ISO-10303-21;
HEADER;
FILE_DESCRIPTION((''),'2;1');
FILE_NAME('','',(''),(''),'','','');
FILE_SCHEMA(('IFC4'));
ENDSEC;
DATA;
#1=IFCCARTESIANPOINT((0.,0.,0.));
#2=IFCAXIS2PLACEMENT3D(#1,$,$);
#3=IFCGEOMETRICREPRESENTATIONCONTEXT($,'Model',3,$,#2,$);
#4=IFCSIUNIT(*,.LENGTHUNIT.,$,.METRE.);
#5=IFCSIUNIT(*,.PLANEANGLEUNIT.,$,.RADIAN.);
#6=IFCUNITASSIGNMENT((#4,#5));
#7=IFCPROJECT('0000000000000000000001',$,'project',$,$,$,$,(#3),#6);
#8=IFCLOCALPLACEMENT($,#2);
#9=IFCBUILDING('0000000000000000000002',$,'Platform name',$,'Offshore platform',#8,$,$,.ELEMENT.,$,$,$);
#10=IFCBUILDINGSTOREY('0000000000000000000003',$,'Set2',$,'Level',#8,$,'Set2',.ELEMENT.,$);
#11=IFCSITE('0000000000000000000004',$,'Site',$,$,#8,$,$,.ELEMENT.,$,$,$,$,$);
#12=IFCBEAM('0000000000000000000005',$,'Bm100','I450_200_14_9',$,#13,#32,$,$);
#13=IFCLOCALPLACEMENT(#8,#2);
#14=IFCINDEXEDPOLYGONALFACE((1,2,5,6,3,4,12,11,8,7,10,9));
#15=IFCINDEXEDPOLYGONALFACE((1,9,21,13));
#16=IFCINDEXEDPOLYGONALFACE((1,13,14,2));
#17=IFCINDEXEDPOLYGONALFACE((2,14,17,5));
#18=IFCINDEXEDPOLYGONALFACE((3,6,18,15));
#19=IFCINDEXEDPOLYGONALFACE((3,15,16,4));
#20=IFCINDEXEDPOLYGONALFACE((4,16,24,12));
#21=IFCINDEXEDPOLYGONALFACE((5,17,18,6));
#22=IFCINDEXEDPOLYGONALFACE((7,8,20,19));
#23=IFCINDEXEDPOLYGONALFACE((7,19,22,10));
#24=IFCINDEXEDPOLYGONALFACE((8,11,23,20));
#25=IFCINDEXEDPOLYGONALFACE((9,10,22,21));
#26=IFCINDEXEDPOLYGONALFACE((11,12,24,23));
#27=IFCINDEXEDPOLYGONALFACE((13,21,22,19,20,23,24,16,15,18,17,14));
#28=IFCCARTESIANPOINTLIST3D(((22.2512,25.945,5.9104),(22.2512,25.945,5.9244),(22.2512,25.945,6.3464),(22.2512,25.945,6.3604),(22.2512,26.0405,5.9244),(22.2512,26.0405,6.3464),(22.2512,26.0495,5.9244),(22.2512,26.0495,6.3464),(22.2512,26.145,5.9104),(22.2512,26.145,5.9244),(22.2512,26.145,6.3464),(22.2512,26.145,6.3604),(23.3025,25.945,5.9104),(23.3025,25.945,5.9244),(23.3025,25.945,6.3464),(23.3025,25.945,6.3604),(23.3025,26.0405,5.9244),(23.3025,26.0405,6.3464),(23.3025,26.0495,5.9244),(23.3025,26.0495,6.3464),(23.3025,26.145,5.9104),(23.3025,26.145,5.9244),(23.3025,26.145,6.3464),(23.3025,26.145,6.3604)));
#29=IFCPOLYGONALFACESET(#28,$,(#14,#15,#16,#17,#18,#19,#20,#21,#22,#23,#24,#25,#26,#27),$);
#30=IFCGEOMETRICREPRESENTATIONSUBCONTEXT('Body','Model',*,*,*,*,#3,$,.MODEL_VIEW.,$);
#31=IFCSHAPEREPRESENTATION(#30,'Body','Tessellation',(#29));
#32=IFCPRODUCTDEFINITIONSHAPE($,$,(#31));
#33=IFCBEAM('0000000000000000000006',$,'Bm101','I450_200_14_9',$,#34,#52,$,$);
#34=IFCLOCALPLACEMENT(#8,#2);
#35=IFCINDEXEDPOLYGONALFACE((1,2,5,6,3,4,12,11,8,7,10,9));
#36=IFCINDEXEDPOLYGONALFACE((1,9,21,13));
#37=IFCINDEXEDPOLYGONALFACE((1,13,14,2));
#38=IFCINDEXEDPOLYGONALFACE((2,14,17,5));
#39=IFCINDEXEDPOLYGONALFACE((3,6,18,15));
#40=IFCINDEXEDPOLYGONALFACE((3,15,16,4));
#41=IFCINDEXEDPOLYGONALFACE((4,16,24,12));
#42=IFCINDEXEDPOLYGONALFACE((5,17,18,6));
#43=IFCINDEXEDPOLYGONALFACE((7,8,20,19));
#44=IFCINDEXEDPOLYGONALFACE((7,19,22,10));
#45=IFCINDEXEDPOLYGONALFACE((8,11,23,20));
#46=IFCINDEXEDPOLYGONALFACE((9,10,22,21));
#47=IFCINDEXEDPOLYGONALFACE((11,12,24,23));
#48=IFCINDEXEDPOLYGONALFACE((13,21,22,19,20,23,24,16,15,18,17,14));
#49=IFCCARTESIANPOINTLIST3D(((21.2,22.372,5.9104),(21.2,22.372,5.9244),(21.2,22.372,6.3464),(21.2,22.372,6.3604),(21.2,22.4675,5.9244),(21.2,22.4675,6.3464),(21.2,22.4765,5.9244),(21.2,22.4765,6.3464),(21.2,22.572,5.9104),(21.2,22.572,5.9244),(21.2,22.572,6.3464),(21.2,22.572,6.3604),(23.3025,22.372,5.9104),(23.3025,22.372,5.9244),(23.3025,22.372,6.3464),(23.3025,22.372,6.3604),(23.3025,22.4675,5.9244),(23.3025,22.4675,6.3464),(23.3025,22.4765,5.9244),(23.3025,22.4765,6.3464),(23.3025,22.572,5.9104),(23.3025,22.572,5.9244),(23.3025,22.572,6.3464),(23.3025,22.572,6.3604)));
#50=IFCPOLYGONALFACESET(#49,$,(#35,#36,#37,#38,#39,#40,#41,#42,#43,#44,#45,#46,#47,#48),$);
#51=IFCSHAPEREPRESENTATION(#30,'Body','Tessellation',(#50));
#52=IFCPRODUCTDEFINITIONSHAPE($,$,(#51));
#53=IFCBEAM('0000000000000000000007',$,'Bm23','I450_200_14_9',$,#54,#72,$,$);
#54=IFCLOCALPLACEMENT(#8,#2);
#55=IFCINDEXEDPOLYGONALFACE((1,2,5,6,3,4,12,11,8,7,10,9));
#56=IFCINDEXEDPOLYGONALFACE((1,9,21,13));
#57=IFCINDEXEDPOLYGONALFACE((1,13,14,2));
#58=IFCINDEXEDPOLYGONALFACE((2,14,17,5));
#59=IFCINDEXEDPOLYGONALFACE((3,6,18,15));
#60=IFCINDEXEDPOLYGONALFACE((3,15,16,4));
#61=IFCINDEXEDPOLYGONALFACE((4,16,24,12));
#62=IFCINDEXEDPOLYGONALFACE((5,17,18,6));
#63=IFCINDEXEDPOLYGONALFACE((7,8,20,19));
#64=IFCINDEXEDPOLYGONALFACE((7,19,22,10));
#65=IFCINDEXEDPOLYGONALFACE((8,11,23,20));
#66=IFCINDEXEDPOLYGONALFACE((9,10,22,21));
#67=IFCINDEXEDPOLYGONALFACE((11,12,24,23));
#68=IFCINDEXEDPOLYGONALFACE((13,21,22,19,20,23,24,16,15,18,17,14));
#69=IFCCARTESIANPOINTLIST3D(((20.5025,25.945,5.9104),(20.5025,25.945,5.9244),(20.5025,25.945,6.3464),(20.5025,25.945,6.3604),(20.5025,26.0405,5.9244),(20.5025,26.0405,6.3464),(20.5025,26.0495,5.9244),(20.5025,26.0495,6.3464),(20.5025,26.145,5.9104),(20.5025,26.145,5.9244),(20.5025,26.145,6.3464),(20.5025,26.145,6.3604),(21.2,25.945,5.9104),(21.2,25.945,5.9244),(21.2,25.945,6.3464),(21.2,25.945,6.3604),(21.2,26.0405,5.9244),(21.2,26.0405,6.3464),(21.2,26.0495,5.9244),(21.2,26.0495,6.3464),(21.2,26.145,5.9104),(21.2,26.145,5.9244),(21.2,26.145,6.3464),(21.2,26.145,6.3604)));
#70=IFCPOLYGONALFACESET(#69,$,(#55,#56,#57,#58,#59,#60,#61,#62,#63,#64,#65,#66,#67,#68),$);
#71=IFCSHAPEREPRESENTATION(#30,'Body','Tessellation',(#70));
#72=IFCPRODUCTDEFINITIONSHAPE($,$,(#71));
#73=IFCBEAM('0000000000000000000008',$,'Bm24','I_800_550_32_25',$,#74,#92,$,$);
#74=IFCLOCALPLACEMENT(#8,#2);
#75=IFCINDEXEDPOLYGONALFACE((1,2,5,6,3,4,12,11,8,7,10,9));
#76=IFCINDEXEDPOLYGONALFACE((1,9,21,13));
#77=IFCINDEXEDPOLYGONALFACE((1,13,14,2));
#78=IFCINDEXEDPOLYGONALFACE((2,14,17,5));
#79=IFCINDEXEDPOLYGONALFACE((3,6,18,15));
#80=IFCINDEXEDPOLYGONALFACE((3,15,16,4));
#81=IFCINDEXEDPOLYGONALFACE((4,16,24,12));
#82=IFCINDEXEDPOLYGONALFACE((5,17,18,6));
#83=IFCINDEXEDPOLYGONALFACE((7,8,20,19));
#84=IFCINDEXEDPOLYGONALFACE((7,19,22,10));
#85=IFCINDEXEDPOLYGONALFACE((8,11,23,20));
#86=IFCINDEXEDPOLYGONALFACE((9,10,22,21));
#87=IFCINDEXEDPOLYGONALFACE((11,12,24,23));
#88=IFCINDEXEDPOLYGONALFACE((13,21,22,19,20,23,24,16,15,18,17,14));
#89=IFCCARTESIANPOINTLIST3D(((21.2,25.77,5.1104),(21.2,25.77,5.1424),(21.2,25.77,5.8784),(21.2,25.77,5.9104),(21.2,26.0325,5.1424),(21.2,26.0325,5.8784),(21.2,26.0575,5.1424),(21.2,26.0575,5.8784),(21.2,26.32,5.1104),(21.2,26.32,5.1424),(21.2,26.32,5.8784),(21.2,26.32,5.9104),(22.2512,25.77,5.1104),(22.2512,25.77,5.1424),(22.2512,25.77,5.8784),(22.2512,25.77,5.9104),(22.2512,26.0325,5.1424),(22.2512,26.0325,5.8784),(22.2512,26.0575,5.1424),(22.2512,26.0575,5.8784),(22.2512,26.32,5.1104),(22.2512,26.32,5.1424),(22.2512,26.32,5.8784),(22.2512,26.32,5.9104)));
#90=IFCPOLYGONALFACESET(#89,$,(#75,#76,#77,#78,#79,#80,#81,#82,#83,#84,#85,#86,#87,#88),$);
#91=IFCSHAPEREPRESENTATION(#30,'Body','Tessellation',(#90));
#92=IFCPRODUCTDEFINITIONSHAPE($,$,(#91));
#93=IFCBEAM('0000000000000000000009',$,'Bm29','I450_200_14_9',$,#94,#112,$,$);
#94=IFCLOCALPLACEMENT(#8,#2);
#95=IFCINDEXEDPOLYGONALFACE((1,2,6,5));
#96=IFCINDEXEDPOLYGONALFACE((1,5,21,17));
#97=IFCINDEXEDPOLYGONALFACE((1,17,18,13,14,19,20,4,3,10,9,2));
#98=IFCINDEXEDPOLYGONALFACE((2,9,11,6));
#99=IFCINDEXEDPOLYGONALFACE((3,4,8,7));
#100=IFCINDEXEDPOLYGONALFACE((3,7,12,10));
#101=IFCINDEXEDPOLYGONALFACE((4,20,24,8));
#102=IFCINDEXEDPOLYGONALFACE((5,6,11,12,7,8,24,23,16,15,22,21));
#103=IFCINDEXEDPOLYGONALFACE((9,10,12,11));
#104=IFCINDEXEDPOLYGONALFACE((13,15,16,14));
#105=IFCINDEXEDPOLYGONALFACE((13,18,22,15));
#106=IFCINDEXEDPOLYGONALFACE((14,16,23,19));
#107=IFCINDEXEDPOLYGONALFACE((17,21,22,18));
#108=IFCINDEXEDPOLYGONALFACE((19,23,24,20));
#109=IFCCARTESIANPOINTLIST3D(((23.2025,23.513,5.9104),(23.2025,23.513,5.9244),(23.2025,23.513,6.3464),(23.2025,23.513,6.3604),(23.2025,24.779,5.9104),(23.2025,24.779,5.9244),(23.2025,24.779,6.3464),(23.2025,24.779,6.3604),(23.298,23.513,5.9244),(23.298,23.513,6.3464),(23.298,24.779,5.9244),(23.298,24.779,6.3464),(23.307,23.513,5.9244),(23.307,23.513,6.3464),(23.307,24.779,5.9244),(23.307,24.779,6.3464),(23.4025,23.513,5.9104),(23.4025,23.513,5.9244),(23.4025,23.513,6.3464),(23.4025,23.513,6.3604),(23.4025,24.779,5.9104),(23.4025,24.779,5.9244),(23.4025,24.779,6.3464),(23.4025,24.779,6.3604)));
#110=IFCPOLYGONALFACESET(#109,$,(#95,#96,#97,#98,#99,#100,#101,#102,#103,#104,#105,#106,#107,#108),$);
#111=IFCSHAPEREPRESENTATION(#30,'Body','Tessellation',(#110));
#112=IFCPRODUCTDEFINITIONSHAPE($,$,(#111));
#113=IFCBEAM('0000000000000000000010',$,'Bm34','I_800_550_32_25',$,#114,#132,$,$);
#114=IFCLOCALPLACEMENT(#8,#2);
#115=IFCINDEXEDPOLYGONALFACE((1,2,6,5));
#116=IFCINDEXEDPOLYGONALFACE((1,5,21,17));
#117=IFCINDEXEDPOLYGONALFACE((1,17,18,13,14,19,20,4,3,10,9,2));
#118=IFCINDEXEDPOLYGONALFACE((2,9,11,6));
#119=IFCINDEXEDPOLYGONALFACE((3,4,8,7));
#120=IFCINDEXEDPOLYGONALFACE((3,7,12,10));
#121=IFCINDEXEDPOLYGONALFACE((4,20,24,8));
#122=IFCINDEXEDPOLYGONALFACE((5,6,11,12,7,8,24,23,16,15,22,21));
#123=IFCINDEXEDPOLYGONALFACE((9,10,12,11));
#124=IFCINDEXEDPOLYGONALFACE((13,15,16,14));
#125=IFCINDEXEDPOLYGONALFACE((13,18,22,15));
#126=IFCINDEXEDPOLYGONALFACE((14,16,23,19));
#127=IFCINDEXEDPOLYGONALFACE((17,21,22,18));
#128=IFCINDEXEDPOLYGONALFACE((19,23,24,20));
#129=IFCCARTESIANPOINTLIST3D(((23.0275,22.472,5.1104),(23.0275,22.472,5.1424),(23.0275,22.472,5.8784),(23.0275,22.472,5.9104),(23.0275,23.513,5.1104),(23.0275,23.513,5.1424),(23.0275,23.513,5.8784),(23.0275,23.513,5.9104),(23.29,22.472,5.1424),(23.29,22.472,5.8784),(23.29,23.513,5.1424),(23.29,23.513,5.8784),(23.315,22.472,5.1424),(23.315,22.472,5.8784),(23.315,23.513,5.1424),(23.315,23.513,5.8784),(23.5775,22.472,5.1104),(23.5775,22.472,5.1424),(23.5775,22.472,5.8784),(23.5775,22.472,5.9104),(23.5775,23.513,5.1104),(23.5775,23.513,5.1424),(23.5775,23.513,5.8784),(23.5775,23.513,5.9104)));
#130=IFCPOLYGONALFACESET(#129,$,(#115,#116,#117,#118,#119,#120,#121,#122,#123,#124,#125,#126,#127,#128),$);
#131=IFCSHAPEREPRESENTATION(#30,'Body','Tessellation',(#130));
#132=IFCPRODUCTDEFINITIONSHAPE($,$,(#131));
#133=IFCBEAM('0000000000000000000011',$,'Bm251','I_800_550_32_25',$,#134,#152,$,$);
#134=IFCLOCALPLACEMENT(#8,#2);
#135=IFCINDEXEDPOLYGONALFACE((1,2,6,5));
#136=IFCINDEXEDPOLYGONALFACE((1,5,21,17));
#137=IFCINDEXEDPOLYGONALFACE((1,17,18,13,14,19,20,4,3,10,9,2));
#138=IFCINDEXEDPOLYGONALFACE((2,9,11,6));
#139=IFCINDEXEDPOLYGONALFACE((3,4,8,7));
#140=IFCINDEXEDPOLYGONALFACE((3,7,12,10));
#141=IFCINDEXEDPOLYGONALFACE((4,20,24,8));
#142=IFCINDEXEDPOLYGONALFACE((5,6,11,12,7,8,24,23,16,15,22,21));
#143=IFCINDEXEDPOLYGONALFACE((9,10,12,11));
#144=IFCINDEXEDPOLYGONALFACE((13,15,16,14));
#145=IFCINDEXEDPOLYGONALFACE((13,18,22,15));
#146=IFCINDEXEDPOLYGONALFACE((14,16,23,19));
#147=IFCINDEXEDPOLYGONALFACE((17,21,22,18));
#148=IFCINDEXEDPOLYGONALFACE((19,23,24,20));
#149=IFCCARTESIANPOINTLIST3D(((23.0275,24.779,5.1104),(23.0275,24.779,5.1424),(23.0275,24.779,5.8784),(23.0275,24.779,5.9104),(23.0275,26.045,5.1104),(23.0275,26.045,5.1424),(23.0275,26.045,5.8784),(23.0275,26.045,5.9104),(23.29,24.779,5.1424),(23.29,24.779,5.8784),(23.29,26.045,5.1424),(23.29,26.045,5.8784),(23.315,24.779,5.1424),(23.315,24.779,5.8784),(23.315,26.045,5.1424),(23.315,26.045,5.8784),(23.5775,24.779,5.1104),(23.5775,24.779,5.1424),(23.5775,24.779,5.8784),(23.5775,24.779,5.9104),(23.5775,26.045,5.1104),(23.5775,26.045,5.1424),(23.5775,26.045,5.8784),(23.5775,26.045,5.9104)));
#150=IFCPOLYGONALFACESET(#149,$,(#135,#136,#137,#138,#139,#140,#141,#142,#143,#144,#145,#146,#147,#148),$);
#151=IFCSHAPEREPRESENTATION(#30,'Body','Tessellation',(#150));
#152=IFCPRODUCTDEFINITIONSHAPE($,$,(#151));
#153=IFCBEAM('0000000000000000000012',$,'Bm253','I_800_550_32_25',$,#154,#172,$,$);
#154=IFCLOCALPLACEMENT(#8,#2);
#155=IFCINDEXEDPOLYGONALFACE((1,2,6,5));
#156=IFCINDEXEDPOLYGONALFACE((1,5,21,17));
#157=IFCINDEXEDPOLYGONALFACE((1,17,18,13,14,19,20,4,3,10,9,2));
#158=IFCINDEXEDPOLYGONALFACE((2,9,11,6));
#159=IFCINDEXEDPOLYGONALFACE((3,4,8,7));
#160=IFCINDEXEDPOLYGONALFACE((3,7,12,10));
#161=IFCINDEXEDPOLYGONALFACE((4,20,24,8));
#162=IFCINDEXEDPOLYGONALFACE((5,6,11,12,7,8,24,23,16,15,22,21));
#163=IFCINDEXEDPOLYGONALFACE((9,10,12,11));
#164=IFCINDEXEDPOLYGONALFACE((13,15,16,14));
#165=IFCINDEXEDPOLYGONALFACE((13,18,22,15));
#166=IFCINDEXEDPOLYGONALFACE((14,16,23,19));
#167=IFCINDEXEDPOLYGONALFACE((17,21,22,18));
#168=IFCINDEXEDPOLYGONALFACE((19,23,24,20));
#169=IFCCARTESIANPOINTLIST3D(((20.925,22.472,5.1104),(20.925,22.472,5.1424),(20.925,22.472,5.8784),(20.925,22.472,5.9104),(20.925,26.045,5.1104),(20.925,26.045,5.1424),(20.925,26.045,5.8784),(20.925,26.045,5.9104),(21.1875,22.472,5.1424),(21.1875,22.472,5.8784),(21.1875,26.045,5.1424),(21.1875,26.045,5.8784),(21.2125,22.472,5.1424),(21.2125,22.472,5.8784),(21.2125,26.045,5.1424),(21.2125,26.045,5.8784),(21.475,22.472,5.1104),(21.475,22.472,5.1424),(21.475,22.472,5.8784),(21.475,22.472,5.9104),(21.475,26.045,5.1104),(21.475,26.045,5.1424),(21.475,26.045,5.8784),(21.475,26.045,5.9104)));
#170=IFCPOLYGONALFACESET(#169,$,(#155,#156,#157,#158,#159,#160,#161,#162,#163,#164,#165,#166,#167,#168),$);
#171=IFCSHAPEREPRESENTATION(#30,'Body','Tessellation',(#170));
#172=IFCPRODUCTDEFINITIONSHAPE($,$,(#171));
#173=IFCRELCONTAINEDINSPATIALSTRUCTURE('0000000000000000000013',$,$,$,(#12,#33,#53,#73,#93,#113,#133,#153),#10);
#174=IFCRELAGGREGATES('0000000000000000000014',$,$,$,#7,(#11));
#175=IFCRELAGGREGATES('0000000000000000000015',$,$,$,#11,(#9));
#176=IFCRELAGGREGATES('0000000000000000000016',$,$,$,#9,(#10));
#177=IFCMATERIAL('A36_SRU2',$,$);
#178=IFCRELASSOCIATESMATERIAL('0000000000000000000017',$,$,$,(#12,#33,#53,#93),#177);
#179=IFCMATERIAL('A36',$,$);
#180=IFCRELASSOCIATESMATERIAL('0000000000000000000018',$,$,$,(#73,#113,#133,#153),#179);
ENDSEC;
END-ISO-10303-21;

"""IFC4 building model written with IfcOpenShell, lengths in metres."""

from ifc_helpers import new_model, si_unit, frame, origin, origin_2d, place, context, subcontext, project, spatial, i_section, extrude, source, transform, mapped, material, element, save


model = new_model("IFC4")

# Units and contexts
model_context = context("Model", 3, world=origin())
body_context = subcontext(model_context, "Body", "Model", "MODEL_VIEW")
ifc_project = project(units=[si_unit("LENGTHUNIT", "METRE"), si_unit("PLANEANGLEUNIT", "RADIAN")], contexts=[model_context])

# Site, building, storey
placement_1 = place(None, origin())
site = spatial("IfcSite", under=ifc_project, at=placement_1, Name="Site", CompositionType="ELEMENT")
building = spatial("IfcBuilding", under=site, at=placement_1, Name="Platform name", ObjectType="Offshore platform", CompositionType="ELEMENT")
storey = spatial("IfcBuildingStorey", under=building, at=placement_1, Name="Set2", ObjectType="Level", LongName="Set2", CompositionType="ELEMENT")

# Beams
ifc_material_1 = material(Name="A36_SRU2")
shared_shape_1 = source(origin(), body_context, "Body", "SweptSolid", [
    extrude(i_section(OverallWidth=0.2, OverallDepth=0.45, WebThickness=0.009, FlangeThickness=0.014, FilletRadius=0.0, at=origin_2d()), frame((0.0, 0.0, 0.0), z_axis=(-1.0, 0.0, 0.0), x_axis=(0.0, -1.0, 0.0)), (0.0, 0.0, 1.0), 1.0513),
])
placement_2 = place(None, origin())
placement_3 = place(placement_2, origin())
placement_4 = place(placement_3, origin())
beam_1_placement = place(placement_4, frame((23.3025, 26.045, 6.1354)))
element("IfcBeam", 1, at=beam_1_placement, inside=storey, material=ifc_material_1, Name="Bm100", Description="I450_200_14_9", context=body_context, shape_type="MappedRepresentation", body=[
    mapped(shared_shape_1, transform((0.0, 0.0, 0.0), scale=1.0)),
])
shared_shape_2 = source(origin(), body_context, "Body", "SweptSolid", [
    extrude(i_section(OverallWidth=0.2, OverallDepth=0.45, WebThickness=0.009, FlangeThickness=0.014, FilletRadius=0.0, at=origin_2d()), frame((0.0, 0.0, 0.0), z_axis=(-1.0, 0.0, 0.0), x_axis=(0.0, -1.0, 0.0)), (0.0, 0.0, 1.0), 2.1025),
])
placement_5 = place(None, origin())
placement_6 = place(placement_5, origin())
placement_7 = place(placement_6, origin())
beam_2_placement = place(placement_7, frame((23.3025, 22.472, 6.1354)))
element("IfcBeam", 2, at=beam_2_placement, inside=storey, material=ifc_material_1, Name="Bm101", Description="I450_200_14_9", context=body_context, shape_type="MappedRepresentation", body=[
    mapped(shared_shape_2, transform((0.0, 0.0, 0.0), scale=1.0)),
])
shared_shape_3 = source(origin(), body_context, "Body", "SweptSolid", [
    extrude(i_section(OverallWidth=0.2, OverallDepth=0.45, WebThickness=0.009, FlangeThickness=0.014, FilletRadius=0.0, at=origin_2d()), frame((0.0, 0.0, 0.0), z_axis=(-1.0, 0.0, 0.0), x_axis=(0.0, -1.0, 0.0)), (0.0, 0.0, 1.0), 0.6975),
])
placement_8 = place(None, origin())
placement_9 = place(placement_8, origin())
placement_10 = place(placement_9, origin())
beam_3_placement = place(placement_10, frame((21.2, 26.045, 6.1354)))
element("IfcBeam", 3, at=beam_3_placement, inside=storey, material=ifc_material_1, Name="Bm23", Description="I450_200_14_9", context=body_context, shape_type="MappedRepresentation", body=[
    mapped(shared_shape_3, transform((0.0, 0.0, 0.0), scale=1.0)),
])
ifc_material_2 = material(Name="A36")
shared_shape_4 = source(origin(), body_context, "Body", "SweptSolid", [
    extrude(i_section(OverallWidth=0.55, OverallDepth=0.8, WebThickness=0.025, FlangeThickness=0.032, FilletRadius=0.0, at=origin_2d()), frame((0.0, 0.0, 0.0), z_axis=(1.0, 0.0, 0.0), x_axis=(0.0, 1.0, 0.0)), (0.0, 0.0, 1.0), 1.0513),
])
placement_11 = place(None, origin())
placement_12 = place(placement_11, origin())
placement_13 = place(placement_12, origin())
beam_4_placement = place(placement_13, frame((21.2, 26.045, 5.5104)))
element("IfcBeam", 4, at=beam_4_placement, inside=storey, material=ifc_material_2, Name="Bm24", Description="I_800_550_32_25", context=body_context, shape_type="MappedRepresentation", body=[
    mapped(shared_shape_4, transform((0.0, 0.0, 0.0), scale=1.0)),
])
shared_shape_5 = source(origin(), body_context, "Body", "SweptSolid", [
    extrude(i_section(OverallWidth=0.2, OverallDepth=0.45, WebThickness=0.009, FlangeThickness=0.014, FilletRadius=0.0, at=origin_2d()), frame((0.0, 0.0, 0.0), z_axis=(0.0, 1.0, 0.0), x_axis=(-1.0, 0.0, 0.0)), (0.0, 0.0, 1.0), 1.266),
])
placement_14 = place(None, origin())
placement_15 = place(placement_14, origin())
placement_16 = place(placement_15, origin())
beam_5_placement = place(placement_16, frame((23.3025, 23.513, 6.1354)))
element("IfcBeam", 5, at=beam_5_placement, inside=storey, material=ifc_material_1, Name="Bm29", Description="I450_200_14_9", context=body_context, shape_type="MappedRepresentation", body=[
    mapped(shared_shape_5, transform((0.0, 0.0, 0.0), scale=1.0)),
])
shared_shape_6 = source(origin(), body_context, "Body", "SweptSolid", [
    extrude(i_section(OverallWidth=0.55, OverallDepth=0.8, WebThickness=0.025, FlangeThickness=0.032, FilletRadius=0.0, at=origin_2d()), frame((0.0, 0.0, 0.0), z_axis=(0.0, -1.0, 0.0), x_axis=(1.0, 0.0, 0.0)), (0.0, 0.0, 1.0), 1.041),
])
placement_17 = place(None, origin())
placement_18 = place(placement_17, origin())
placement_19 = place(placement_18, origin())
beam_6_placement = place(placement_19, frame((23.3025, 23.513, 5.5104)))
element("IfcBeam", 6, at=beam_6_placement, inside=storey, material=ifc_material_2, Name="Bm34", Description="I_800_550_32_25", context=body_context, shape_type="MappedRepresentation", body=[
    mapped(shared_shape_6, transform((0.0, 0.0, 0.0), scale=1.0)),
])
shared_shape_7 = source(origin(), body_context, "Body", "SweptSolid", [
    extrude(i_section(OverallWidth=0.55, OverallDepth=0.8, WebThickness=0.025, FlangeThickness=0.032, FilletRadius=0.0, at=origin_2d()), frame((0.0, 0.0, 0.0), z_axis=(0.0, -1.0, 0.0), x_axis=(1.0, 0.0, 0.0)), (0.0, 0.0, 1.0), 1.266),
])
placement_20 = place(None, origin())
placement_21 = place(placement_20, origin())
placement_22 = place(placement_21, origin())
beam_7_placement = place(placement_22, frame((23.3025, 26.045, 5.5104)))
element("IfcBeam", 7, at=beam_7_placement, inside=storey, material=ifc_material_2, Name="Bm251", Description="I_800_550_32_25", context=body_context, shape_type="MappedRepresentation", body=[
    mapped(shared_shape_7, transform((0.0, 0.0, 0.0), scale=1.0)),
])
shared_shape_8 = source(origin(), body_context, "Body", "SweptSolid", [
    extrude(i_section(OverallWidth=0.55, OverallDepth=0.8, WebThickness=0.025, FlangeThickness=0.032, FilletRadius=0.0, at=origin_2d()), frame((0.0, 0.0, 0.0), z_axis=(0.0, -1.0, 0.0), x_axis=(1.0, 0.0, 0.0)), (0.0, 0.0, 1.0), 3.573),
])
placement_23 = place(None, origin())
placement_24 = place(placement_23, origin())
placement_25 = place(placement_24, origin())
beam_8_placement = place(placement_25, frame((21.2, 26.045, 5.5104)))
element("IfcBeam", 8, at=beam_8_placement, inside=storey, material=ifc_material_2, Name="Bm253", Description="I_800_550_32_25", context=body_context, shape_type="MappedRepresentation", body=[
    mapped(shared_shape_8, transform((0.0, 0.0, 0.0), scale=1.0)),
])

save(model, "model.ifc")
